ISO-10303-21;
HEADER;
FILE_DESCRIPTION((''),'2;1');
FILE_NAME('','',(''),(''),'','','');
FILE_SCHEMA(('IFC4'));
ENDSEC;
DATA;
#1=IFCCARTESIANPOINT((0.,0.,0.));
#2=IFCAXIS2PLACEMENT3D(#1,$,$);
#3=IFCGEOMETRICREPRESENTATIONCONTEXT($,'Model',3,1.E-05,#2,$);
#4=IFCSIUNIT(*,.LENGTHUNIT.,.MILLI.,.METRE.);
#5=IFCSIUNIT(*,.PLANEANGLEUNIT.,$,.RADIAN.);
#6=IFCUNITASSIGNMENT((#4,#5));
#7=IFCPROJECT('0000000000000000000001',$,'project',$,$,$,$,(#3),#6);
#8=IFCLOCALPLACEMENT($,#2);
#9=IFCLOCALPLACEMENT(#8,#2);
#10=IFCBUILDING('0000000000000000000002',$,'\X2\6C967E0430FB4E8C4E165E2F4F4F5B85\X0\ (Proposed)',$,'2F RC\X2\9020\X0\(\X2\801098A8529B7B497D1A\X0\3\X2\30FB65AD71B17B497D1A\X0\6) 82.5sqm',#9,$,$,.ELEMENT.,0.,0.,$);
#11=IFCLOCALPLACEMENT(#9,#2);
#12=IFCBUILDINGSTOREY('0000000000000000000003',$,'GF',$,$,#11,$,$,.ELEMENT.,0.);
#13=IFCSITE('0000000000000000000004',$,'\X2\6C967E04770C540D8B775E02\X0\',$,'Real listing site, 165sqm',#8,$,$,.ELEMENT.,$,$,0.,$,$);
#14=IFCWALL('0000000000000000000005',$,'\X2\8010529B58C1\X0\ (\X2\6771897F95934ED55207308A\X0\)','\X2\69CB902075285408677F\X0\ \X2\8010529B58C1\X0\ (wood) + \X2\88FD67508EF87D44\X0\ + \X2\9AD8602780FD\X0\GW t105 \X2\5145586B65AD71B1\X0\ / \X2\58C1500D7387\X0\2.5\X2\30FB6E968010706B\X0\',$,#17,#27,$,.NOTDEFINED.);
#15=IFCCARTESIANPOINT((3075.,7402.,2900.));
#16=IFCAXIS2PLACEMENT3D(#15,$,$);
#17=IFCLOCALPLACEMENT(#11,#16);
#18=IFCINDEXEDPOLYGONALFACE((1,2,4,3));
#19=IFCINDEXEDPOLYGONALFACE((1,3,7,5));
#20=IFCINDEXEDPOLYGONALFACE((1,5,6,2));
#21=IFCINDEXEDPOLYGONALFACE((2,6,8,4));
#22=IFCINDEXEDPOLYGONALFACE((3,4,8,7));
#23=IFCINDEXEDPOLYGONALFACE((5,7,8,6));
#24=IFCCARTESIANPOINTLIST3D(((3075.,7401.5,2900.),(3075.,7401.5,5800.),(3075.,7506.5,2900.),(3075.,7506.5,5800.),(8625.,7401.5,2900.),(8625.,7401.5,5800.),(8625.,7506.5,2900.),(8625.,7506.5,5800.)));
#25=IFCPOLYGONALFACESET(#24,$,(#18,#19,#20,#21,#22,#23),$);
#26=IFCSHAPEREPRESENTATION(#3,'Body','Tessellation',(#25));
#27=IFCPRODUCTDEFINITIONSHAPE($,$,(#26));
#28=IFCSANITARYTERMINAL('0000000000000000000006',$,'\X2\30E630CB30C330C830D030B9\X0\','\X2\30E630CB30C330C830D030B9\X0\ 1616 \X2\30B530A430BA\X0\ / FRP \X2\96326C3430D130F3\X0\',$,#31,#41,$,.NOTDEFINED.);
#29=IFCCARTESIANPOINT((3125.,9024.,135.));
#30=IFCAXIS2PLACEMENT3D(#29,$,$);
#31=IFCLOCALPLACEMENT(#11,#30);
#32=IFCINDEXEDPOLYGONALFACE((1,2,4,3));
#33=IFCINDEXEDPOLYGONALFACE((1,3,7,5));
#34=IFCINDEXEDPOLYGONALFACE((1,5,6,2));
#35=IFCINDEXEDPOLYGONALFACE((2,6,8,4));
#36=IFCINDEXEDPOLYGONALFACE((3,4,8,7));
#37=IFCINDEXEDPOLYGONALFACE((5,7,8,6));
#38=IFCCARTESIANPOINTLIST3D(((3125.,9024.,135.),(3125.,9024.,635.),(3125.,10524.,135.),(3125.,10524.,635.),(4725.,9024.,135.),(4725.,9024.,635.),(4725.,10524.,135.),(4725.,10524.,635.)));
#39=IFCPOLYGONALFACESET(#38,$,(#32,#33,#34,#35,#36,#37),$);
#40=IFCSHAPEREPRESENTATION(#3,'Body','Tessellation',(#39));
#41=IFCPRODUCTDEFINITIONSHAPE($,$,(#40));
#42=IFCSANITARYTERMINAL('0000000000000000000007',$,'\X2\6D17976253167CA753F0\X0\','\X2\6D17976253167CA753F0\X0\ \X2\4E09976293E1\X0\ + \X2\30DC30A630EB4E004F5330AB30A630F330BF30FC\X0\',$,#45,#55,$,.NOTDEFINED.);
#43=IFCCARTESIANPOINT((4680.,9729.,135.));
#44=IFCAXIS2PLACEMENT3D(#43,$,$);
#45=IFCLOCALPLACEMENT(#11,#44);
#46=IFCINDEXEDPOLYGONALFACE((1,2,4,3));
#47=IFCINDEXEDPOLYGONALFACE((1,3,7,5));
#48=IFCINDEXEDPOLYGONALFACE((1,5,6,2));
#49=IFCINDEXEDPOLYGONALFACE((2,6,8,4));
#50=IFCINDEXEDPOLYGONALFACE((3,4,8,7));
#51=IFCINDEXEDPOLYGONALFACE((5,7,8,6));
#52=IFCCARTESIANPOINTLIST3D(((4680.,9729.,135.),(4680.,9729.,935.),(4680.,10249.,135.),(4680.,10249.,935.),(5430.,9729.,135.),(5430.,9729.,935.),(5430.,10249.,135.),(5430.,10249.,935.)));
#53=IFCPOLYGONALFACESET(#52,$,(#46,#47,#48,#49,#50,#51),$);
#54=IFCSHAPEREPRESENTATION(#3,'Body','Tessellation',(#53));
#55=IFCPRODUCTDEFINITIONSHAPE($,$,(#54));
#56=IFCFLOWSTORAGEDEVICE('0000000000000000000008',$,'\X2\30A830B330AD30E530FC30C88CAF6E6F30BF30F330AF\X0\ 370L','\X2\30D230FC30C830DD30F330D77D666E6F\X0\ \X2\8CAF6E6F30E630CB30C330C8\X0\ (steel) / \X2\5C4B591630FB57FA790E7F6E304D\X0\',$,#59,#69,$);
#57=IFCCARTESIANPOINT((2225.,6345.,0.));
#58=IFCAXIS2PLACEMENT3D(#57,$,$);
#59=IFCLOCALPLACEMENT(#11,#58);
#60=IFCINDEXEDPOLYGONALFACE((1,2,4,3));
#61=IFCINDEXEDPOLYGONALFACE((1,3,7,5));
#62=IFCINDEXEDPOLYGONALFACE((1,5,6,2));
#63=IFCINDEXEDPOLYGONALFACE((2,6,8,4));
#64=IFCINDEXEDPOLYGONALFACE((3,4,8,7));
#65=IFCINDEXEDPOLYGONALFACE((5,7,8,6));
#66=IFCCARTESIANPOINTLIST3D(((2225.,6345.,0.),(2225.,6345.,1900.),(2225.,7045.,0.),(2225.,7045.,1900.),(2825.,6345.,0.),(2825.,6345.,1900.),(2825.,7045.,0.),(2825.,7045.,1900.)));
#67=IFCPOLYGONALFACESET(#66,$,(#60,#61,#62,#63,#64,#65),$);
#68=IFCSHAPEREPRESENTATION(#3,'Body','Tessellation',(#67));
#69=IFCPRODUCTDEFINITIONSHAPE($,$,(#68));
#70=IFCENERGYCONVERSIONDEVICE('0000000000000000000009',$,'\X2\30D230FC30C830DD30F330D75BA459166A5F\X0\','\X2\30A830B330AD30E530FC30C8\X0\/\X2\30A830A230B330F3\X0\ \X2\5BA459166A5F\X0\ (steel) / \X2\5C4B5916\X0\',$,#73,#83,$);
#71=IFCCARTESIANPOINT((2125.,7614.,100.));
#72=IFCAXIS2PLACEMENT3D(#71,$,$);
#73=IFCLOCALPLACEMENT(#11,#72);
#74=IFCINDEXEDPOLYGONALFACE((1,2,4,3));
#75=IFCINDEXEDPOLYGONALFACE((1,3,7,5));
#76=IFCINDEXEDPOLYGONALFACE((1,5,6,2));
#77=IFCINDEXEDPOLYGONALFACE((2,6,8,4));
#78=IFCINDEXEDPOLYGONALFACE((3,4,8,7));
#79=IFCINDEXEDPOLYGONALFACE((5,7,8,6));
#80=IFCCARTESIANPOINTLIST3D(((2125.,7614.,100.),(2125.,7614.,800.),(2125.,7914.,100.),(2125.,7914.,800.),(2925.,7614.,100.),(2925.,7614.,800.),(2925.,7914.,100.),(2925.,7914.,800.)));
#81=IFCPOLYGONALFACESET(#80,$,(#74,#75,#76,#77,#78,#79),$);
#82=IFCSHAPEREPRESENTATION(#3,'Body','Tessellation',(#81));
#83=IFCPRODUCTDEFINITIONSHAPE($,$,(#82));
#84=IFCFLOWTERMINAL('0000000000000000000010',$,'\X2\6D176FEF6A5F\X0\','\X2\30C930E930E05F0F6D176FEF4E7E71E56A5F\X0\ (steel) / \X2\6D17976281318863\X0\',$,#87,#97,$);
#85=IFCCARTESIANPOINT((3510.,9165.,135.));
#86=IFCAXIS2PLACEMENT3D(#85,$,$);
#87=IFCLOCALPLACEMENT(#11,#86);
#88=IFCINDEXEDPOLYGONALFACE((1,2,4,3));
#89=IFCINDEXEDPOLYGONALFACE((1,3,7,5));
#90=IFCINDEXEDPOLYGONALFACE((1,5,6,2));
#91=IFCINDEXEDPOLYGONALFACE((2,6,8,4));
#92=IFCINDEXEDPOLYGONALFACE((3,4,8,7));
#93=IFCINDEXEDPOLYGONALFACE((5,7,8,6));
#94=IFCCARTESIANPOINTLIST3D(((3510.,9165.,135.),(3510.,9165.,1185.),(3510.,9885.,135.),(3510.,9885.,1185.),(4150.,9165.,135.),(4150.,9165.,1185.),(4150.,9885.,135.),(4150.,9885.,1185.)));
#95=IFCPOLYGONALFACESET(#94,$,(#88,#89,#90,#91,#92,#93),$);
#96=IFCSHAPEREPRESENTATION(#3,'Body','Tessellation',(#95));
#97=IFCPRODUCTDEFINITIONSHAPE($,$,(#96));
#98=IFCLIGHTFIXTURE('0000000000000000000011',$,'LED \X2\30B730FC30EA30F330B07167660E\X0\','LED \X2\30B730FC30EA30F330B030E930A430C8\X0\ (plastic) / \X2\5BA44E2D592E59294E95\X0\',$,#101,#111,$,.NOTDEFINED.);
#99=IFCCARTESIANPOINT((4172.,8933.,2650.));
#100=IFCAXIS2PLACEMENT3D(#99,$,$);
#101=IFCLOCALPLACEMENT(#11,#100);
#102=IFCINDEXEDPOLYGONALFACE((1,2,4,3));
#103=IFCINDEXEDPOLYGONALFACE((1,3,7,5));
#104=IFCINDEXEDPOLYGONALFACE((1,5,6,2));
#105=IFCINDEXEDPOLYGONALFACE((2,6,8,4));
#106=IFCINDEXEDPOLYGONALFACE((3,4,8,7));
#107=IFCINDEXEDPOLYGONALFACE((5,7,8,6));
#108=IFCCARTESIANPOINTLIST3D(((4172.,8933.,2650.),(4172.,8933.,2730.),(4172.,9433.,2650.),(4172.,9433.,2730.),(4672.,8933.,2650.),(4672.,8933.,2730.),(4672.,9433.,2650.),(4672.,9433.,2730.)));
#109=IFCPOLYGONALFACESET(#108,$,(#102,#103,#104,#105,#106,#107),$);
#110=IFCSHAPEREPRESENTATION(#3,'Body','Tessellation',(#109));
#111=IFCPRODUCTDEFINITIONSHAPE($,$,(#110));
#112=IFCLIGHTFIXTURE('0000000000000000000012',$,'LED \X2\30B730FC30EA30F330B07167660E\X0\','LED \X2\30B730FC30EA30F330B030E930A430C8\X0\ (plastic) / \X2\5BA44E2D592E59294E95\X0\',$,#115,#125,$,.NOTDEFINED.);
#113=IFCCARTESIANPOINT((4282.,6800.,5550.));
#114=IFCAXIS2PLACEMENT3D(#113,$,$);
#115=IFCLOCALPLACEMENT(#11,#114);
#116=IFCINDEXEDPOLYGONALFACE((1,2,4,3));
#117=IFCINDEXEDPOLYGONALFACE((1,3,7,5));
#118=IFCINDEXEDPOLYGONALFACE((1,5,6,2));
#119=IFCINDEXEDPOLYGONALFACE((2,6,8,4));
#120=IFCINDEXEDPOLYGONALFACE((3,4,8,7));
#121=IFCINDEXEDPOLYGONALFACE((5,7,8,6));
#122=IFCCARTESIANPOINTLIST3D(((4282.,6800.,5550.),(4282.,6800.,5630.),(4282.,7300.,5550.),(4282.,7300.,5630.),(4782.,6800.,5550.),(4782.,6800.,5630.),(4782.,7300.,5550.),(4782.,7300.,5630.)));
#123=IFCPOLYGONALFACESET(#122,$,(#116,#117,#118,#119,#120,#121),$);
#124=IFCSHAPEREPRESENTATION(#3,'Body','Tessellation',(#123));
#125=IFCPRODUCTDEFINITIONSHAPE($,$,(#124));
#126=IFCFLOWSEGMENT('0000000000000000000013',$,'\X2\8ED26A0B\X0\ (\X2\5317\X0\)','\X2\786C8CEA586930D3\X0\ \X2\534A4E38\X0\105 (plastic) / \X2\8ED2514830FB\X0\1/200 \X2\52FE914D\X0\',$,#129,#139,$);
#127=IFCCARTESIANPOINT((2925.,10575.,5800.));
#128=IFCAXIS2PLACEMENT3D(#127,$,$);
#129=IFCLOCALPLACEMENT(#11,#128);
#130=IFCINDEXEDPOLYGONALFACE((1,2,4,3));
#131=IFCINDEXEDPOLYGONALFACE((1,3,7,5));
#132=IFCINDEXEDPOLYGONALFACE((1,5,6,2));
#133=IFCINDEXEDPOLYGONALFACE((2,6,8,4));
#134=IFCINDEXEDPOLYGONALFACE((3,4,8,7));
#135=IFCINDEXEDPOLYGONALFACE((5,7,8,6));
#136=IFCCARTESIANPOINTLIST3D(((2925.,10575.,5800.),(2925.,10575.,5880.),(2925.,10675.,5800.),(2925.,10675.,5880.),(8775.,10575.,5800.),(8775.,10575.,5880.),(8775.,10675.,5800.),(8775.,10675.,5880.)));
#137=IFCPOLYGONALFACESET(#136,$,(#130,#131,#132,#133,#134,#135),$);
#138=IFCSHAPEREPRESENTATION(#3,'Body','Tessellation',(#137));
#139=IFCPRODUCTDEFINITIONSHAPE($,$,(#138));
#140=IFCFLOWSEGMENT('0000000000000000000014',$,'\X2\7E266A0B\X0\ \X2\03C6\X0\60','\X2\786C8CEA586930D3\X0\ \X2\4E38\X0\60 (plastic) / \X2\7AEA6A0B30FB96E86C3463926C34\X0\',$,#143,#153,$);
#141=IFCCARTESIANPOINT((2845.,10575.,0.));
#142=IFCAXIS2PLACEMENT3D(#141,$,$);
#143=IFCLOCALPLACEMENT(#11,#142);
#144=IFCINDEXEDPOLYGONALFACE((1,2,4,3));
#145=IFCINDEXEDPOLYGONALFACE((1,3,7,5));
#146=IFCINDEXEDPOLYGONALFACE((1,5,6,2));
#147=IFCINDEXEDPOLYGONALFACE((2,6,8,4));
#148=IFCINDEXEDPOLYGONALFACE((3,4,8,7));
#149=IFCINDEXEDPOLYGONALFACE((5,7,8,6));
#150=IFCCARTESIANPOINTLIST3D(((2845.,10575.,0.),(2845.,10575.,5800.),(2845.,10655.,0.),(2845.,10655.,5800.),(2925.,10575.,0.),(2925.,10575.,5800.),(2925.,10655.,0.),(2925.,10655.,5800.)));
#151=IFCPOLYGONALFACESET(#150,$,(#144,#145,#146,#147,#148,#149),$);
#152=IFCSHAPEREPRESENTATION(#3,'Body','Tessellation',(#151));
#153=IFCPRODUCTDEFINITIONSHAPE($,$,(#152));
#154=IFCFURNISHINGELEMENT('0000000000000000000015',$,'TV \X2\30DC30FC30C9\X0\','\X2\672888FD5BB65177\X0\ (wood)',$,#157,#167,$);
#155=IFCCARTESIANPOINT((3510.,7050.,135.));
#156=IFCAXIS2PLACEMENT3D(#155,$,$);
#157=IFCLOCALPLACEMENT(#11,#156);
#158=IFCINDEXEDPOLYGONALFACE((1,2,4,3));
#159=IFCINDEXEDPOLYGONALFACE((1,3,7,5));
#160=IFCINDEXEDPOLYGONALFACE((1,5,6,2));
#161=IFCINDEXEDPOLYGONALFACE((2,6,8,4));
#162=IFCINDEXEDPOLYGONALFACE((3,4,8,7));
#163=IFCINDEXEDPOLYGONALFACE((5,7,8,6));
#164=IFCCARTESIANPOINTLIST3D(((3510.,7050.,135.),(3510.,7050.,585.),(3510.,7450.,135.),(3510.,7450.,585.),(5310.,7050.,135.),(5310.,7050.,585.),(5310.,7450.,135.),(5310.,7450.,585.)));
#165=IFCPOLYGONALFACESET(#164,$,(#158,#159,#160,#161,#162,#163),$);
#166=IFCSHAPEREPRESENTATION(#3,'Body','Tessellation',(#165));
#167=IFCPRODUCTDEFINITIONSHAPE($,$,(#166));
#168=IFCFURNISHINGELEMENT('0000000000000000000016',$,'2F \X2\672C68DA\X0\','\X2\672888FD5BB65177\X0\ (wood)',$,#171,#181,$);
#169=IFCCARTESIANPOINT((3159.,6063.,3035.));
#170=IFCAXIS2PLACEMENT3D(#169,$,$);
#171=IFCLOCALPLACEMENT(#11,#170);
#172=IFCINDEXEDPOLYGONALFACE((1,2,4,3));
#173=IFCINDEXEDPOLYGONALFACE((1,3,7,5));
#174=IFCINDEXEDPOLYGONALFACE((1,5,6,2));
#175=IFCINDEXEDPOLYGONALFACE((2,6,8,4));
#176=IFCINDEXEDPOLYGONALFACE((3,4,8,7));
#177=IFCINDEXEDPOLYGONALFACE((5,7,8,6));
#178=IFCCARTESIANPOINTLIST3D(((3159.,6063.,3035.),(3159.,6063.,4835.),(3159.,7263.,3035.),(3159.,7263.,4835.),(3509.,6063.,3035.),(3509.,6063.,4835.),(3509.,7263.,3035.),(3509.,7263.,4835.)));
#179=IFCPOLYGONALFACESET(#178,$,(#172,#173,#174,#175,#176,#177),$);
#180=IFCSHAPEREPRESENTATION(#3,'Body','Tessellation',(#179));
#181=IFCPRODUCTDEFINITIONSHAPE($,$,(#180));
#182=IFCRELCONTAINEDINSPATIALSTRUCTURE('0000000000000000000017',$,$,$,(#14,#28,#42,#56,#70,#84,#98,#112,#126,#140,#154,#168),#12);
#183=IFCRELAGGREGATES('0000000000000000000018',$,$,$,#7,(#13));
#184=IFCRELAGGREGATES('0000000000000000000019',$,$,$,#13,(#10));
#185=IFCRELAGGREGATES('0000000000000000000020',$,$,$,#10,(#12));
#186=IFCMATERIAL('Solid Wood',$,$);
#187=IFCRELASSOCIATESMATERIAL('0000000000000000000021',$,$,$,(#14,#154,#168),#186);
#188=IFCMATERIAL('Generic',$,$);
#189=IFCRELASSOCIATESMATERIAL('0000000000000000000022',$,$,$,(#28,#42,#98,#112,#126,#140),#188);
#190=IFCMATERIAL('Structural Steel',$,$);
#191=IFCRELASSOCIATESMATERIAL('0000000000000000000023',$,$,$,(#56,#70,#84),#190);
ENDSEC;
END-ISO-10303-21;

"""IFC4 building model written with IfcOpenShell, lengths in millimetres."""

from ifc_helpers import new_model, si_unit, frame, frame_2d, origin, place, context, project, spatial, rectangle, extrude, material, element, save


model = new_model("IFC4")

# Units and contexts
model_context = context("Model", 3, precision=1e-05, world=origin())
ifc_project = project(units=[si_unit("LENGTHUNIT", "METRE", prefix="MILLI"), si_unit("PLANEANGLEUNIT", "RADIAN")], contexts=[model_context])

# Site, building, storey
site_placement = place(None, origin())
site = spatial("IfcSite", under=ifc_project, at=site_placement, Name="沖縄県名護市", ObjectType="Real listing site, 165sqm", CompositionType="ELEMENT", RefElevation=0.0)
building_placement = place(site_placement, origin())
building = spatial("IfcBuilding", under=site, at=building_placement, Name="沖縄・二世帯住宅 (Proposed)", ObjectType="2F RC造(耐風力等級3・断熱等級6) 82.5sqm", CompositionType="ELEMENT", ElevationOfRefHeight=0.0, ElevationOfTerrain=0.0)
storey_placement = place(building_placement, origin())
storey = spatial("IfcBuildingStorey", under=building, at=storey_placement, Name="GF", CompositionType="ELEMENT", Elevation=0.0)

# Shared definitions
ifc_material_1 = material(Name="Solid Wood")

# Wall
wall_1_placement = place(storey_placement, frame((3075.0, 7402.0, 2900.0)))
element("IfcWall", 1, at=wall_1_placement, inside=storey, material=ifc_material_1, Name="耐力壁 (東西間仕切り)", Description="構造用合板 耐力壁 (wood) + 製材軸組 + 高性能GW t105 充填断熱 / 壁倍率2.5・準耐火", PredefinedType="NOTDEFINED", context=model_context, shape_type="SweptSolid", body=[
    extrude(rectangle(XDim=5550.0, YDim=105.0, at=frame_2d((2775.0, 52.0))), frame((3075.0, 7402.0, 2900.0)), (0.0, 0.0, 1.0), 2900.0),
])

# Sanitary terminals
ifc_material_2 = material(Name="Generic")
sanitary_terminal_1_placement = place(storey_placement, frame((3125.0, 9024.0, 135.0)))
element("IfcSanitaryTerminal", 2, at=sanitary_terminal_1_placement, inside=storey, material=ifc_material_2, Name="ユニットバス", Description="ユニットバス 1616 サイズ / FRP 防水パン", PredefinedType="NOTDEFINED", context=model_context, shape_type="SweptSolid", body=[
    extrude(rectangle(XDim=1600.0, YDim=1500.0, at=frame_2d((800.0, 750.0))), frame((3125.0, 9024.0, 135.0)), (0.0, 0.0, 1.0), 500.0),
])
sanitary_terminal_2_placement = place(storey_placement, frame((4680.0, 9729.0, 135.0)))
element("IfcSanitaryTerminal", 3, at=sanitary_terminal_2_placement, inside=storey, material=ifc_material_2, Name="洗面化粧台", Description="洗面化粧台 三面鏡 + ボウル一体カウンター", PredefinedType="NOTDEFINED", context=model_context, shape_type="SweptSolid", body=[
    extrude(rectangle(XDim=750.0, YDim=520.0, at=frame_2d((375.0, 260.0))), frame((4680.0, 9729.0, 135.0)), (0.0, 0.0, 1.0), 800.0),
])

# Flow storage device
ifc_material_3 = material(Name="Structural Steel")
flow_storage_device_placement = place(storey_placement, frame((2225.0, 6345.0, 0.0)))
element("IfcFlowStorageDevice", 4, at=flow_storage_device_placement, inside=storey, material=ifc_material_3, Name="エコキュート貯湯タンク 370L", Description="ヒートポンプ給湯 貯湯ユニット (steel) / 屋外・基礎置き", context=model_context, shape_type="SweptSolid", body=[
    extrude(rectangle(XDim=600.0, YDim=700.0, at=frame_2d((300.0, 350.0))), frame((2225.0, 6345.0, 0.0)), (0.0, 0.0, 1.0), 1900.0),
])

# Energy conversion device
energy_conversion_device_placement = place(storey_placement, frame((2125.0, 7614.0, 100.0)))
element("IfcEnergyConversionDevice", 5, at=energy_conversion_device_placement, inside=storey, material=ifc_material_3, Name="ヒートポンプ室外機", Description="エコキュート/エアコン 室外機 (steel) / 屋外", context=model_context, shape_type="SweptSolid", body=[
    extrude(rectangle(XDim=800.0, YDim=300.0, at=frame_2d((400.0, 150.0))), frame((2125.0, 7614.0, 100.0)), (0.0, 0.0, 1.0), 700.0),
])

# Flow terminal
flow_terminal_placement = place(storey_placement, frame((3510.0, 9165.0, 135.0)))
element("IfcFlowTerminal", 6, at=flow_terminal_placement, inside=storey, material=ifc_material_3, Name="洗濯機", Description="ドラム式洗濯乾燥機 (steel) / 洗面脱衣", context=model_context, shape_type="SweptSolid", body=[
    extrude(rectangle(XDim=640.0, YDim=720.0, at=frame_2d((320.0, 360.0))), frame((3510.0, 9165.0, 135.0)), (0.0, 0.0, 1.0), 1050.0),
])

# Light fixtures
light_fixture_1_placement = place(storey_placement, frame((4172.0, 8933.0, 2650.0)))
element("IfcLightFixture", 7, at=light_fixture_1_placement, inside=storey, material=ifc_material_2, Name="LED シーリング照明", Description="LED シーリングライト (plastic) / 室中央天井", PredefinedType="NOTDEFINED", context=model_context, shape_type="SweptSolid", body=[
    extrude(rectangle(XDim=500.0, YDim=500.0, at=frame_2d((250.0, 250.0))), frame((4172.0, 8933.0, 2650.0)), (0.0, 0.0, 1.0), 80.0),
])
light_fixture_2_placement = place(storey_placement, frame((4282.0, 6800.0, 5550.0)))
element("IfcLightFixture", 8, at=light_fixture_2_placement, inside=storey, material=ifc_material_2, Name="LED シーリング照明", Description="LED シーリングライト (plastic) / 室中央天井", PredefinedType="NOTDEFINED", context=model_context, shape_type="SweptSolid", body=[
    extrude(rectangle(XDim=500.0, YDim=500.0, at=frame_2d((250.0, 250.0))), frame((4282.0, 6800.0, 5550.0)), (0.0, 0.0, 1.0), 80.0),
])

# Flow segments
flow_segment_1_placement = place(storey_placement, frame((2925.0, 10575.0, 5800.0)))
element("IfcFlowSegment", 9, at=flow_segment_1_placement, inside=storey, material=ifc_material_2, Name="軒樋 (北)", Description="硬質塩ビ 半丸105 (plastic) / 軒先・1/200 勾配", context=model_context, shape_type="SweptSolid", body=[
    extrude(rectangle(XDim=5850.0, YDim=100.0, at=frame_2d((2925.0, 50.0))), frame((2925.0, 10575.0, 5800.0)), (0.0, 0.0, 1.0), 80.0),
])
flow_segment_2_placement = place(storey_placement, frame((2845.0, 10575.0, 0.0)))
element("IfcFlowSegment", 10, at=flow_segment_2_placement, inside=storey, material=ifc_material_2, Name="縦樋 φ60", Description="硬質塩ビ 丸60 (plastic) / 竪樋・雨水排水", context=model_context, shape_type="SweptSolid", body=[
    extrude(rectangle(XDim=80.0, YDim=80.0, at=frame_2d((40.0, 40.0))), frame((2845.0, 10575.0, 0.0)), (0.0, 0.0, 1.0), 5800.0),
])

# Furnishing elements
furnishing_1_placement = place(storey_placement, frame((3510.0, 7050.0, 135.0)))
element("IfcFurnishingElement", 11, at=furnishing_1_placement, inside=storey, material=ifc_material_1, Name="TV ボード", Description="木製家具 (wood)", context=model_context, shape_type="SweptSolid", body=[
    extrude(rectangle(XDim=1800.0, YDim=400.0, at=frame_2d((900.0, 200.0))), frame((3510.0, 7050.0, 135.0)), (0.0, 0.0, 1.0), 450.0),
])
furnishing_2_placement = place(storey_placement, frame((3159.0, 6063.0, 3035.0)))
element("IfcFurnishingElement", 12, at=furnishing_2_placement, inside=storey, material=ifc_material_1, Name="2F 本棚", Description="木製家具 (wood)", context=model_context, shape_type="SweptSolid", body=[
    extrude(rectangle(XDim=350.0, YDim=1200.0, at=frame_2d((175.0, 600.0))), frame((3159.0, 6063.0, 3035.0)), (0.0, 0.0, 1.0), 1800.0),
])

save(model, "model.ifc")
